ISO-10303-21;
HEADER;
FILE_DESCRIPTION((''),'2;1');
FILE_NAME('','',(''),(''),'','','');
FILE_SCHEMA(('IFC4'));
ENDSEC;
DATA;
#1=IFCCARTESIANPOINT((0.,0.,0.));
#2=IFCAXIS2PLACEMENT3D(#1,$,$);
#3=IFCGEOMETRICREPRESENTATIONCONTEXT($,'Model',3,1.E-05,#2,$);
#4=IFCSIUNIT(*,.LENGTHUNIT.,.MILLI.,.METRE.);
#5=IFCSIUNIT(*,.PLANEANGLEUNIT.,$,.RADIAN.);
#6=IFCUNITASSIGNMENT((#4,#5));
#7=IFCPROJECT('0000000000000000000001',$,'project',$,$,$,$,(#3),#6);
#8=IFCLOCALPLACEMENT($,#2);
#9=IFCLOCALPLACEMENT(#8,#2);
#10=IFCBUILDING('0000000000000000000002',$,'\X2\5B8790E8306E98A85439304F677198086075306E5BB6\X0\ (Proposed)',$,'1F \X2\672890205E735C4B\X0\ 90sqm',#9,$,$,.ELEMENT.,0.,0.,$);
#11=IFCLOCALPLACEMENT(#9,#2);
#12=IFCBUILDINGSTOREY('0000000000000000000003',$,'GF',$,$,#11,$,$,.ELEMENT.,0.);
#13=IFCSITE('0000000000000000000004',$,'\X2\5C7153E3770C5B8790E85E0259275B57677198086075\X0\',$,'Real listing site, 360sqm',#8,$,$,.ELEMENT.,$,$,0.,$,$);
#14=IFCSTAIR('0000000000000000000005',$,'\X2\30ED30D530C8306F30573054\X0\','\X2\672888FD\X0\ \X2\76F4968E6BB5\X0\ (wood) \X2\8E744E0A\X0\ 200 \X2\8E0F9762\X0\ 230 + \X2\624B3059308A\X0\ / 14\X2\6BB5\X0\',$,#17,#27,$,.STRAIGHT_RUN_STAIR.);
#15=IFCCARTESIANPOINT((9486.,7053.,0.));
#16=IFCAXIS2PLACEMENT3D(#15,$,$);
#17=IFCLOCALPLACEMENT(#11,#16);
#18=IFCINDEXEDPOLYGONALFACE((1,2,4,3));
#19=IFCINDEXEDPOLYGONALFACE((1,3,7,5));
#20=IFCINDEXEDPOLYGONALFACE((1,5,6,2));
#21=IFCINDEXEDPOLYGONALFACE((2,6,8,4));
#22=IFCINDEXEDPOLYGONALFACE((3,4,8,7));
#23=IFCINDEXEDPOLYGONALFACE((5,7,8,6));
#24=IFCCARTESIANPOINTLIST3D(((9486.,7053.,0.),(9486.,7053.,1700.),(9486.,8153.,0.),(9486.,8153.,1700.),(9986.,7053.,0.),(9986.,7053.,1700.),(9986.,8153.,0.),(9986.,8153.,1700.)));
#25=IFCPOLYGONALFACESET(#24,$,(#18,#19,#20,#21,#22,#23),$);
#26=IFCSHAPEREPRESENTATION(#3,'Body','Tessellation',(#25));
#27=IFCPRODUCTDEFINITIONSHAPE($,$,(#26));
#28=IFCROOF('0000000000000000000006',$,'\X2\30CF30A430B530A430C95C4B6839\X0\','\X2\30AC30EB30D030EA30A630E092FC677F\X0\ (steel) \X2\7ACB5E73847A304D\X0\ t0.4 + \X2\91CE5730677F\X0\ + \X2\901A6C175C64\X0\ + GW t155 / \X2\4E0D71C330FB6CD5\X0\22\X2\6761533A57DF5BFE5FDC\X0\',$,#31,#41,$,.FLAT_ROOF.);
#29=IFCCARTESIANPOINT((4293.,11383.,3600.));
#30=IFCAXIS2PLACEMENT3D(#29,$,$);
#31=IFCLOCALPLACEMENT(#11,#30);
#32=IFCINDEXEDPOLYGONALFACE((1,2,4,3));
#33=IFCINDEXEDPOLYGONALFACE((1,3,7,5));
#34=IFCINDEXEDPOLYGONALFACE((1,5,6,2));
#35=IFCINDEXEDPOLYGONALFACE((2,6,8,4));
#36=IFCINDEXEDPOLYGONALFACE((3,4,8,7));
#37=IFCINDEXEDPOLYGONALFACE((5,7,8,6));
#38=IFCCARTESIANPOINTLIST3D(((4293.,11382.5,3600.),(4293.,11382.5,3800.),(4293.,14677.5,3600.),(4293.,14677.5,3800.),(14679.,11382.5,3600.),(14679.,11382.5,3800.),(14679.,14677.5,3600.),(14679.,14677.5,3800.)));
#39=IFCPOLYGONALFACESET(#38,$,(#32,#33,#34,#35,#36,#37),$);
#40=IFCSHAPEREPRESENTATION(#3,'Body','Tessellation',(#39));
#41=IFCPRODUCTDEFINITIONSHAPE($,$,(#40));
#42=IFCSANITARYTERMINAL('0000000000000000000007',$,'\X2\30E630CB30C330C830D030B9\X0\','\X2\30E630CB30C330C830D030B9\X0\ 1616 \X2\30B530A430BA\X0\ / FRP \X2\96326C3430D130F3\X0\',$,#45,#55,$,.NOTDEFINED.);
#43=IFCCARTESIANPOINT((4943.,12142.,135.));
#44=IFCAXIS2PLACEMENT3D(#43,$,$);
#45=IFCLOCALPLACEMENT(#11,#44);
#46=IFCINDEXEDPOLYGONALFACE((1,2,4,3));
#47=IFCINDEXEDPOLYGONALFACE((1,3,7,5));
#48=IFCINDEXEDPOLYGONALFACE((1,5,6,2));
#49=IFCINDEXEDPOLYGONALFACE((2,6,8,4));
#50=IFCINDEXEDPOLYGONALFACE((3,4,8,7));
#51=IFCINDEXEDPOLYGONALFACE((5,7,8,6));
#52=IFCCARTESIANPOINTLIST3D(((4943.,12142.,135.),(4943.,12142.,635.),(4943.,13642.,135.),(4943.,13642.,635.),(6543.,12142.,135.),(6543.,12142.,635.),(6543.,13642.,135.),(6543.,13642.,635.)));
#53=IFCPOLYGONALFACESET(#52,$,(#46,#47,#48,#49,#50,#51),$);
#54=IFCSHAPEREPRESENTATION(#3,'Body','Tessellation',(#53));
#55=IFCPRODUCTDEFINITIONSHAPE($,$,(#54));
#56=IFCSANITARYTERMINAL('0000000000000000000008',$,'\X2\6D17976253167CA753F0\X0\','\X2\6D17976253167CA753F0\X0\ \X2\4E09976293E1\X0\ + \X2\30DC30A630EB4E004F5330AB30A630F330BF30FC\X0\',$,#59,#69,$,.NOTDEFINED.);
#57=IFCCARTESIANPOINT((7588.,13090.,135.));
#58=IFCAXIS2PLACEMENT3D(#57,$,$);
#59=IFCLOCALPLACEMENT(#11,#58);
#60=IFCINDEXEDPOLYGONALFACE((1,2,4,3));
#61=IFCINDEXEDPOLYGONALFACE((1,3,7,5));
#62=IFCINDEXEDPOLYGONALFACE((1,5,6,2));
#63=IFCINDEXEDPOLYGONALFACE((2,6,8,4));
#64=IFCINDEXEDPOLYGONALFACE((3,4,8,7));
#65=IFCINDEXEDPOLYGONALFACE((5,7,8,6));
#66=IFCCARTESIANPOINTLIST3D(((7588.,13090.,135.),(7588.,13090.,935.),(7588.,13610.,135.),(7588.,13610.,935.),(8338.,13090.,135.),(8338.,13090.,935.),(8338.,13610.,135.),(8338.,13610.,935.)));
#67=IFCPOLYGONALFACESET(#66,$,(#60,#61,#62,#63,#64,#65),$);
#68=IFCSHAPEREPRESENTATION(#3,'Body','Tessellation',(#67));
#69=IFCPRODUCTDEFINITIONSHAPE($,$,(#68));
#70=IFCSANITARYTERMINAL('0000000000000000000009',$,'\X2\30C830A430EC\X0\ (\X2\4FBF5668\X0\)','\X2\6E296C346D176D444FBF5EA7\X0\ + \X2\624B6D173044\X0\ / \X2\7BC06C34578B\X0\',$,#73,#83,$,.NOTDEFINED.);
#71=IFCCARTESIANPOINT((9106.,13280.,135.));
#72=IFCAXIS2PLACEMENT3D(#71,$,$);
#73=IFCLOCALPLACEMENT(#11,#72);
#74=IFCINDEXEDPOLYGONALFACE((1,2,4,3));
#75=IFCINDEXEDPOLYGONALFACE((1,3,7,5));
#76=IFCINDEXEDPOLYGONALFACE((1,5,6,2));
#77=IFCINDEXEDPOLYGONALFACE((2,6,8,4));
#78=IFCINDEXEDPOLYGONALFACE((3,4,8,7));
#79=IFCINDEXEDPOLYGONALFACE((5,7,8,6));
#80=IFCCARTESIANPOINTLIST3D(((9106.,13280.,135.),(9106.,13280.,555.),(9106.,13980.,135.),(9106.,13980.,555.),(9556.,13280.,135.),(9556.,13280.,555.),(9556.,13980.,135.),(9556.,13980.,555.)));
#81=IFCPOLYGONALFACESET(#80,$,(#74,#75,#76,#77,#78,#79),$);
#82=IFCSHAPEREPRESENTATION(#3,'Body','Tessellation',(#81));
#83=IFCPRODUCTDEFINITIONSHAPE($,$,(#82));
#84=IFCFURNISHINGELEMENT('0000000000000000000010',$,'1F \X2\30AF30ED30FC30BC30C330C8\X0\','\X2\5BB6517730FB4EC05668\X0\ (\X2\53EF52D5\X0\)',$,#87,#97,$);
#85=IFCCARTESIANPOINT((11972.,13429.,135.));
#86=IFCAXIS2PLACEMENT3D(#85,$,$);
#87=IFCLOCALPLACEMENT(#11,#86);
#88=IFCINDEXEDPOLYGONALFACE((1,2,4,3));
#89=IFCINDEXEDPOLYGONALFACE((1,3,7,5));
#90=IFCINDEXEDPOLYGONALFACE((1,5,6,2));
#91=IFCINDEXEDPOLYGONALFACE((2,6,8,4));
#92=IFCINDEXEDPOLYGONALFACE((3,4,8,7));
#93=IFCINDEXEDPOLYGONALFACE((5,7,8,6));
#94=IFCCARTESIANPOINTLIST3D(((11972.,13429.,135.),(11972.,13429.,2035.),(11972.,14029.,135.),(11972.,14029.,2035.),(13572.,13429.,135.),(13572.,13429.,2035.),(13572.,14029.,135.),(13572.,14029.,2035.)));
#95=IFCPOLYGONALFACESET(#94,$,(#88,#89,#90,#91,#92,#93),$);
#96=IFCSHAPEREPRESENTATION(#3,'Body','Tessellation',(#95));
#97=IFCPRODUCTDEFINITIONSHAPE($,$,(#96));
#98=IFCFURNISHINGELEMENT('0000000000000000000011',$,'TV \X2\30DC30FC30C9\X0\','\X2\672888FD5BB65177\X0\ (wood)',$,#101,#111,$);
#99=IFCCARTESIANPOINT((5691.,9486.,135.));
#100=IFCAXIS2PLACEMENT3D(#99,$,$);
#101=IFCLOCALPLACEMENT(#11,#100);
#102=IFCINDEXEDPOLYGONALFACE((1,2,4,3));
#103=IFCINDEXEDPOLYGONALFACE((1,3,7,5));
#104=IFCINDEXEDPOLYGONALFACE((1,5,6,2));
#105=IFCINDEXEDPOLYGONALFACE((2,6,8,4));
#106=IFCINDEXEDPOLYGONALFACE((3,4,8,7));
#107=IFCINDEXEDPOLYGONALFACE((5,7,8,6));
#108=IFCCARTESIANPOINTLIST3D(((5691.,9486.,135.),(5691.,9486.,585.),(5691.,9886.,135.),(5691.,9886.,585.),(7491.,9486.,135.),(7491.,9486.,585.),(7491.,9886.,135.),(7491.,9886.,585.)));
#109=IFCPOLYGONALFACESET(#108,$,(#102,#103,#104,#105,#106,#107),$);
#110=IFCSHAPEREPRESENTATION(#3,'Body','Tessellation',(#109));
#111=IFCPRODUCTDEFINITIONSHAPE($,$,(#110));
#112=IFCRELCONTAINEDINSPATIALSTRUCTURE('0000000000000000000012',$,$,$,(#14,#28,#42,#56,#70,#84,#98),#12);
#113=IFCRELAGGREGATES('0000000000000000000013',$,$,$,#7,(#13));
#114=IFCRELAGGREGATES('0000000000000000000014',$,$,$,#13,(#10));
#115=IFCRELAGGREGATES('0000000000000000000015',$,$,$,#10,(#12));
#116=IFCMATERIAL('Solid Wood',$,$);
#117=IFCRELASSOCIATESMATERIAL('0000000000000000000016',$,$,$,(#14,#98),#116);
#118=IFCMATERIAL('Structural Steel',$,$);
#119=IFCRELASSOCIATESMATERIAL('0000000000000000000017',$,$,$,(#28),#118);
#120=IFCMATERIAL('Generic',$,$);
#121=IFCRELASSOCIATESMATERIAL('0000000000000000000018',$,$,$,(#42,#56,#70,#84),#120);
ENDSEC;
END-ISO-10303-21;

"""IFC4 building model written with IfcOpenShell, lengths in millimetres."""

from ifc_helpers import new_model, si_unit, frame, frame_2d, origin, place, context, project, spatial, rectangle, extrude, material, element, save


model = new_model("IFC4")

# Units and contexts
model_context = context("Model", 3, precision=1e-05, world=origin())
ifc_project = project(units=[si_unit("LENGTHUNIT", "METRE", prefix="MILLI"), si_unit("PLANEANGLEUNIT", "RADIAN")], contexts=[model_context])

# Site, building, storey
site_placement = place(None, origin())
site = spatial("IfcSite", under=ifc_project, at=site_placement, Name="山口県宇部市大字東須恵", ObjectType="Real listing site, 360sqm", CompositionType="ELEMENT", RefElevation=0.0)
building_placement = place(site_placement, origin())
building = spatial("IfcBuilding", under=site, at=building_placement, Name="宇部の風吹く東須恵の家 (Proposed)", ObjectType="1F 木造平屋 90sqm", CompositionType="ELEMENT", ElevationOfRefHeight=0.0, ElevationOfTerrain=0.0)
storey_placement = place(building_placement, origin())
storey = spatial("IfcBuildingStorey", under=building, at=storey_placement, Name="GF", CompositionType="ELEMENT", Elevation=0.0)

# Shared definitions
ifc_material_1 = material(Name="Solid Wood")

# Stair
stair_placement = place(storey_placement, frame((9486.0, 7053.0, 0.0)))
element("IfcStair", 1, at=stair_placement, inside=storey, material=ifc_material_1, Name="ロフトはしご", Description="木製 直階段 (wood) 蹴上 200 踏面 230 + 手すり / 14段", PredefinedType="STRAIGHT_RUN_STAIR", context=model_context, shape_type="SweptSolid", body=[
    extrude(rectangle(XDim=500.0, YDim=1100.0, at=frame_2d((250.0, 550.0))), frame((9486.0, 7053.0, 0.0)), (0.0, 0.0, 1.0), 1700.0),
])

# Roof
ifc_material_2 = material(Name="Structural Steel")
roof_placement = place(storey_placement, frame((4293.0, 11383.0, 3600.0)))
element("IfcRoof", 2, at=roof_placement, inside=storey, material=ifc_material_2, Name="ハイサイド屋根", Description="ガルバリウム鋼板 (steel) 立平葺き t0.4 + 野地板 + 通気層 + GW t155 / 不燃・法22条区域対応", PredefinedType="FLAT_ROOF", context=model_context, shape_type="SweptSolid", body=[
    extrude(rectangle(XDim=10386.0, YDim=3295.0, at=frame_2d((5193.0, 1647.0))), frame((4293.0, 11383.0, 3600.0)), (0.0, 0.0, 1.0), 200.0),
])

# Sanitary terminals
ifc_material_3 = material(Name="Generic")
sanitary_terminal_1_placement = place(storey_placement, frame((4943.0, 12142.0, 135.0)))
element("IfcSanitaryTerminal", 3, at=sanitary_terminal_1_placement, inside=storey, material=ifc_material_3, Name="ユニットバス", Description="ユニットバス 1616 サイズ / FRP 防水パン", PredefinedType="NOTDEFINED", context=model_context, shape_type="SweptSolid", body=[
    extrude(rectangle(XDim=1600.0, YDim=1500.0, at=frame_2d((800.0, 750.0))), frame((4943.0, 12142.0, 135.0)), (0.0, 0.0, 1.0), 500.0),
])
sanitary_terminal_2_placement = place(storey_placement, frame((7588.0, 13090.0, 135.0)))
element("IfcSanitaryTerminal", 4, at=sanitary_terminal_2_placement, inside=storey, material=ifc_material_3, Name="洗面化粧台", Description="洗面化粧台 三面鏡 + ボウル一体カウンター", PredefinedType="NOTDEFINED", context=model_context, shape_type="SweptSolid", body=[
    extrude(rectangle(XDim=750.0, YDim=520.0, at=frame_2d((375.0, 260.0))), frame((7588.0, 13090.0, 135.0)), (0.0, 0.0, 1.0), 800.0),
])
sanitary_terminal_3_placement = place(storey_placement, frame((9106.0, 13280.0, 135.0)))
element("IfcSanitaryTerminal", 5, at=sanitary_terminal_3_placement, inside=storey, material=ifc_material_3, Name="トイレ (便器)", Description="温水洗浄便座 + 手洗い / 節水型", PredefinedType="NOTDEFINED", context=model_context, shape_type="SweptSolid", body=[
    extrude(rectangle(XDim=450.0, YDim=700.0, at=frame_2d((225.0, 350.0))), frame((9106.0, 13280.0, 135.0)), (0.0, 0.0, 1.0), 420.0),
])

# Furnishing elements
furnishing_1_placement = place(storey_placement, frame((11972.0, 13429.0, 135.0)))
element("IfcFurnishingElement", 6, at=furnishing_1_placement, inside=storey, material=ifc_material_3, Name="1F クローゼット", Description="家具・什器 (可動)", context=model_context, shape_type="SweptSolid", body=[
    extrude(rectangle(XDim=1600.0, YDim=600.0, at=frame_2d((800.0, 300.0))), frame((11972.0, 13429.0, 135.0)), (0.0, 0.0, 1.0), 1900.0),
])
furnishing_2_placement = place(storey_placement, frame((5691.0, 9486.0, 135.0)))
element("IfcFurnishingElement", 7, at=furnishing_2_placement, inside=storey, material=ifc_material_1, Name="TV ボード", Description="木製家具 (wood)", context=model_context, shape_type="SweptSolid", body=[
    extrude(rectangle(XDim=1800.0, YDim=400.0, at=frame_2d((900.0, 200.0))), frame((5691.0, 9486.0, 135.0)), (0.0, 0.0, 1.0), 450.0),
])

save(model, "model.ifc")
